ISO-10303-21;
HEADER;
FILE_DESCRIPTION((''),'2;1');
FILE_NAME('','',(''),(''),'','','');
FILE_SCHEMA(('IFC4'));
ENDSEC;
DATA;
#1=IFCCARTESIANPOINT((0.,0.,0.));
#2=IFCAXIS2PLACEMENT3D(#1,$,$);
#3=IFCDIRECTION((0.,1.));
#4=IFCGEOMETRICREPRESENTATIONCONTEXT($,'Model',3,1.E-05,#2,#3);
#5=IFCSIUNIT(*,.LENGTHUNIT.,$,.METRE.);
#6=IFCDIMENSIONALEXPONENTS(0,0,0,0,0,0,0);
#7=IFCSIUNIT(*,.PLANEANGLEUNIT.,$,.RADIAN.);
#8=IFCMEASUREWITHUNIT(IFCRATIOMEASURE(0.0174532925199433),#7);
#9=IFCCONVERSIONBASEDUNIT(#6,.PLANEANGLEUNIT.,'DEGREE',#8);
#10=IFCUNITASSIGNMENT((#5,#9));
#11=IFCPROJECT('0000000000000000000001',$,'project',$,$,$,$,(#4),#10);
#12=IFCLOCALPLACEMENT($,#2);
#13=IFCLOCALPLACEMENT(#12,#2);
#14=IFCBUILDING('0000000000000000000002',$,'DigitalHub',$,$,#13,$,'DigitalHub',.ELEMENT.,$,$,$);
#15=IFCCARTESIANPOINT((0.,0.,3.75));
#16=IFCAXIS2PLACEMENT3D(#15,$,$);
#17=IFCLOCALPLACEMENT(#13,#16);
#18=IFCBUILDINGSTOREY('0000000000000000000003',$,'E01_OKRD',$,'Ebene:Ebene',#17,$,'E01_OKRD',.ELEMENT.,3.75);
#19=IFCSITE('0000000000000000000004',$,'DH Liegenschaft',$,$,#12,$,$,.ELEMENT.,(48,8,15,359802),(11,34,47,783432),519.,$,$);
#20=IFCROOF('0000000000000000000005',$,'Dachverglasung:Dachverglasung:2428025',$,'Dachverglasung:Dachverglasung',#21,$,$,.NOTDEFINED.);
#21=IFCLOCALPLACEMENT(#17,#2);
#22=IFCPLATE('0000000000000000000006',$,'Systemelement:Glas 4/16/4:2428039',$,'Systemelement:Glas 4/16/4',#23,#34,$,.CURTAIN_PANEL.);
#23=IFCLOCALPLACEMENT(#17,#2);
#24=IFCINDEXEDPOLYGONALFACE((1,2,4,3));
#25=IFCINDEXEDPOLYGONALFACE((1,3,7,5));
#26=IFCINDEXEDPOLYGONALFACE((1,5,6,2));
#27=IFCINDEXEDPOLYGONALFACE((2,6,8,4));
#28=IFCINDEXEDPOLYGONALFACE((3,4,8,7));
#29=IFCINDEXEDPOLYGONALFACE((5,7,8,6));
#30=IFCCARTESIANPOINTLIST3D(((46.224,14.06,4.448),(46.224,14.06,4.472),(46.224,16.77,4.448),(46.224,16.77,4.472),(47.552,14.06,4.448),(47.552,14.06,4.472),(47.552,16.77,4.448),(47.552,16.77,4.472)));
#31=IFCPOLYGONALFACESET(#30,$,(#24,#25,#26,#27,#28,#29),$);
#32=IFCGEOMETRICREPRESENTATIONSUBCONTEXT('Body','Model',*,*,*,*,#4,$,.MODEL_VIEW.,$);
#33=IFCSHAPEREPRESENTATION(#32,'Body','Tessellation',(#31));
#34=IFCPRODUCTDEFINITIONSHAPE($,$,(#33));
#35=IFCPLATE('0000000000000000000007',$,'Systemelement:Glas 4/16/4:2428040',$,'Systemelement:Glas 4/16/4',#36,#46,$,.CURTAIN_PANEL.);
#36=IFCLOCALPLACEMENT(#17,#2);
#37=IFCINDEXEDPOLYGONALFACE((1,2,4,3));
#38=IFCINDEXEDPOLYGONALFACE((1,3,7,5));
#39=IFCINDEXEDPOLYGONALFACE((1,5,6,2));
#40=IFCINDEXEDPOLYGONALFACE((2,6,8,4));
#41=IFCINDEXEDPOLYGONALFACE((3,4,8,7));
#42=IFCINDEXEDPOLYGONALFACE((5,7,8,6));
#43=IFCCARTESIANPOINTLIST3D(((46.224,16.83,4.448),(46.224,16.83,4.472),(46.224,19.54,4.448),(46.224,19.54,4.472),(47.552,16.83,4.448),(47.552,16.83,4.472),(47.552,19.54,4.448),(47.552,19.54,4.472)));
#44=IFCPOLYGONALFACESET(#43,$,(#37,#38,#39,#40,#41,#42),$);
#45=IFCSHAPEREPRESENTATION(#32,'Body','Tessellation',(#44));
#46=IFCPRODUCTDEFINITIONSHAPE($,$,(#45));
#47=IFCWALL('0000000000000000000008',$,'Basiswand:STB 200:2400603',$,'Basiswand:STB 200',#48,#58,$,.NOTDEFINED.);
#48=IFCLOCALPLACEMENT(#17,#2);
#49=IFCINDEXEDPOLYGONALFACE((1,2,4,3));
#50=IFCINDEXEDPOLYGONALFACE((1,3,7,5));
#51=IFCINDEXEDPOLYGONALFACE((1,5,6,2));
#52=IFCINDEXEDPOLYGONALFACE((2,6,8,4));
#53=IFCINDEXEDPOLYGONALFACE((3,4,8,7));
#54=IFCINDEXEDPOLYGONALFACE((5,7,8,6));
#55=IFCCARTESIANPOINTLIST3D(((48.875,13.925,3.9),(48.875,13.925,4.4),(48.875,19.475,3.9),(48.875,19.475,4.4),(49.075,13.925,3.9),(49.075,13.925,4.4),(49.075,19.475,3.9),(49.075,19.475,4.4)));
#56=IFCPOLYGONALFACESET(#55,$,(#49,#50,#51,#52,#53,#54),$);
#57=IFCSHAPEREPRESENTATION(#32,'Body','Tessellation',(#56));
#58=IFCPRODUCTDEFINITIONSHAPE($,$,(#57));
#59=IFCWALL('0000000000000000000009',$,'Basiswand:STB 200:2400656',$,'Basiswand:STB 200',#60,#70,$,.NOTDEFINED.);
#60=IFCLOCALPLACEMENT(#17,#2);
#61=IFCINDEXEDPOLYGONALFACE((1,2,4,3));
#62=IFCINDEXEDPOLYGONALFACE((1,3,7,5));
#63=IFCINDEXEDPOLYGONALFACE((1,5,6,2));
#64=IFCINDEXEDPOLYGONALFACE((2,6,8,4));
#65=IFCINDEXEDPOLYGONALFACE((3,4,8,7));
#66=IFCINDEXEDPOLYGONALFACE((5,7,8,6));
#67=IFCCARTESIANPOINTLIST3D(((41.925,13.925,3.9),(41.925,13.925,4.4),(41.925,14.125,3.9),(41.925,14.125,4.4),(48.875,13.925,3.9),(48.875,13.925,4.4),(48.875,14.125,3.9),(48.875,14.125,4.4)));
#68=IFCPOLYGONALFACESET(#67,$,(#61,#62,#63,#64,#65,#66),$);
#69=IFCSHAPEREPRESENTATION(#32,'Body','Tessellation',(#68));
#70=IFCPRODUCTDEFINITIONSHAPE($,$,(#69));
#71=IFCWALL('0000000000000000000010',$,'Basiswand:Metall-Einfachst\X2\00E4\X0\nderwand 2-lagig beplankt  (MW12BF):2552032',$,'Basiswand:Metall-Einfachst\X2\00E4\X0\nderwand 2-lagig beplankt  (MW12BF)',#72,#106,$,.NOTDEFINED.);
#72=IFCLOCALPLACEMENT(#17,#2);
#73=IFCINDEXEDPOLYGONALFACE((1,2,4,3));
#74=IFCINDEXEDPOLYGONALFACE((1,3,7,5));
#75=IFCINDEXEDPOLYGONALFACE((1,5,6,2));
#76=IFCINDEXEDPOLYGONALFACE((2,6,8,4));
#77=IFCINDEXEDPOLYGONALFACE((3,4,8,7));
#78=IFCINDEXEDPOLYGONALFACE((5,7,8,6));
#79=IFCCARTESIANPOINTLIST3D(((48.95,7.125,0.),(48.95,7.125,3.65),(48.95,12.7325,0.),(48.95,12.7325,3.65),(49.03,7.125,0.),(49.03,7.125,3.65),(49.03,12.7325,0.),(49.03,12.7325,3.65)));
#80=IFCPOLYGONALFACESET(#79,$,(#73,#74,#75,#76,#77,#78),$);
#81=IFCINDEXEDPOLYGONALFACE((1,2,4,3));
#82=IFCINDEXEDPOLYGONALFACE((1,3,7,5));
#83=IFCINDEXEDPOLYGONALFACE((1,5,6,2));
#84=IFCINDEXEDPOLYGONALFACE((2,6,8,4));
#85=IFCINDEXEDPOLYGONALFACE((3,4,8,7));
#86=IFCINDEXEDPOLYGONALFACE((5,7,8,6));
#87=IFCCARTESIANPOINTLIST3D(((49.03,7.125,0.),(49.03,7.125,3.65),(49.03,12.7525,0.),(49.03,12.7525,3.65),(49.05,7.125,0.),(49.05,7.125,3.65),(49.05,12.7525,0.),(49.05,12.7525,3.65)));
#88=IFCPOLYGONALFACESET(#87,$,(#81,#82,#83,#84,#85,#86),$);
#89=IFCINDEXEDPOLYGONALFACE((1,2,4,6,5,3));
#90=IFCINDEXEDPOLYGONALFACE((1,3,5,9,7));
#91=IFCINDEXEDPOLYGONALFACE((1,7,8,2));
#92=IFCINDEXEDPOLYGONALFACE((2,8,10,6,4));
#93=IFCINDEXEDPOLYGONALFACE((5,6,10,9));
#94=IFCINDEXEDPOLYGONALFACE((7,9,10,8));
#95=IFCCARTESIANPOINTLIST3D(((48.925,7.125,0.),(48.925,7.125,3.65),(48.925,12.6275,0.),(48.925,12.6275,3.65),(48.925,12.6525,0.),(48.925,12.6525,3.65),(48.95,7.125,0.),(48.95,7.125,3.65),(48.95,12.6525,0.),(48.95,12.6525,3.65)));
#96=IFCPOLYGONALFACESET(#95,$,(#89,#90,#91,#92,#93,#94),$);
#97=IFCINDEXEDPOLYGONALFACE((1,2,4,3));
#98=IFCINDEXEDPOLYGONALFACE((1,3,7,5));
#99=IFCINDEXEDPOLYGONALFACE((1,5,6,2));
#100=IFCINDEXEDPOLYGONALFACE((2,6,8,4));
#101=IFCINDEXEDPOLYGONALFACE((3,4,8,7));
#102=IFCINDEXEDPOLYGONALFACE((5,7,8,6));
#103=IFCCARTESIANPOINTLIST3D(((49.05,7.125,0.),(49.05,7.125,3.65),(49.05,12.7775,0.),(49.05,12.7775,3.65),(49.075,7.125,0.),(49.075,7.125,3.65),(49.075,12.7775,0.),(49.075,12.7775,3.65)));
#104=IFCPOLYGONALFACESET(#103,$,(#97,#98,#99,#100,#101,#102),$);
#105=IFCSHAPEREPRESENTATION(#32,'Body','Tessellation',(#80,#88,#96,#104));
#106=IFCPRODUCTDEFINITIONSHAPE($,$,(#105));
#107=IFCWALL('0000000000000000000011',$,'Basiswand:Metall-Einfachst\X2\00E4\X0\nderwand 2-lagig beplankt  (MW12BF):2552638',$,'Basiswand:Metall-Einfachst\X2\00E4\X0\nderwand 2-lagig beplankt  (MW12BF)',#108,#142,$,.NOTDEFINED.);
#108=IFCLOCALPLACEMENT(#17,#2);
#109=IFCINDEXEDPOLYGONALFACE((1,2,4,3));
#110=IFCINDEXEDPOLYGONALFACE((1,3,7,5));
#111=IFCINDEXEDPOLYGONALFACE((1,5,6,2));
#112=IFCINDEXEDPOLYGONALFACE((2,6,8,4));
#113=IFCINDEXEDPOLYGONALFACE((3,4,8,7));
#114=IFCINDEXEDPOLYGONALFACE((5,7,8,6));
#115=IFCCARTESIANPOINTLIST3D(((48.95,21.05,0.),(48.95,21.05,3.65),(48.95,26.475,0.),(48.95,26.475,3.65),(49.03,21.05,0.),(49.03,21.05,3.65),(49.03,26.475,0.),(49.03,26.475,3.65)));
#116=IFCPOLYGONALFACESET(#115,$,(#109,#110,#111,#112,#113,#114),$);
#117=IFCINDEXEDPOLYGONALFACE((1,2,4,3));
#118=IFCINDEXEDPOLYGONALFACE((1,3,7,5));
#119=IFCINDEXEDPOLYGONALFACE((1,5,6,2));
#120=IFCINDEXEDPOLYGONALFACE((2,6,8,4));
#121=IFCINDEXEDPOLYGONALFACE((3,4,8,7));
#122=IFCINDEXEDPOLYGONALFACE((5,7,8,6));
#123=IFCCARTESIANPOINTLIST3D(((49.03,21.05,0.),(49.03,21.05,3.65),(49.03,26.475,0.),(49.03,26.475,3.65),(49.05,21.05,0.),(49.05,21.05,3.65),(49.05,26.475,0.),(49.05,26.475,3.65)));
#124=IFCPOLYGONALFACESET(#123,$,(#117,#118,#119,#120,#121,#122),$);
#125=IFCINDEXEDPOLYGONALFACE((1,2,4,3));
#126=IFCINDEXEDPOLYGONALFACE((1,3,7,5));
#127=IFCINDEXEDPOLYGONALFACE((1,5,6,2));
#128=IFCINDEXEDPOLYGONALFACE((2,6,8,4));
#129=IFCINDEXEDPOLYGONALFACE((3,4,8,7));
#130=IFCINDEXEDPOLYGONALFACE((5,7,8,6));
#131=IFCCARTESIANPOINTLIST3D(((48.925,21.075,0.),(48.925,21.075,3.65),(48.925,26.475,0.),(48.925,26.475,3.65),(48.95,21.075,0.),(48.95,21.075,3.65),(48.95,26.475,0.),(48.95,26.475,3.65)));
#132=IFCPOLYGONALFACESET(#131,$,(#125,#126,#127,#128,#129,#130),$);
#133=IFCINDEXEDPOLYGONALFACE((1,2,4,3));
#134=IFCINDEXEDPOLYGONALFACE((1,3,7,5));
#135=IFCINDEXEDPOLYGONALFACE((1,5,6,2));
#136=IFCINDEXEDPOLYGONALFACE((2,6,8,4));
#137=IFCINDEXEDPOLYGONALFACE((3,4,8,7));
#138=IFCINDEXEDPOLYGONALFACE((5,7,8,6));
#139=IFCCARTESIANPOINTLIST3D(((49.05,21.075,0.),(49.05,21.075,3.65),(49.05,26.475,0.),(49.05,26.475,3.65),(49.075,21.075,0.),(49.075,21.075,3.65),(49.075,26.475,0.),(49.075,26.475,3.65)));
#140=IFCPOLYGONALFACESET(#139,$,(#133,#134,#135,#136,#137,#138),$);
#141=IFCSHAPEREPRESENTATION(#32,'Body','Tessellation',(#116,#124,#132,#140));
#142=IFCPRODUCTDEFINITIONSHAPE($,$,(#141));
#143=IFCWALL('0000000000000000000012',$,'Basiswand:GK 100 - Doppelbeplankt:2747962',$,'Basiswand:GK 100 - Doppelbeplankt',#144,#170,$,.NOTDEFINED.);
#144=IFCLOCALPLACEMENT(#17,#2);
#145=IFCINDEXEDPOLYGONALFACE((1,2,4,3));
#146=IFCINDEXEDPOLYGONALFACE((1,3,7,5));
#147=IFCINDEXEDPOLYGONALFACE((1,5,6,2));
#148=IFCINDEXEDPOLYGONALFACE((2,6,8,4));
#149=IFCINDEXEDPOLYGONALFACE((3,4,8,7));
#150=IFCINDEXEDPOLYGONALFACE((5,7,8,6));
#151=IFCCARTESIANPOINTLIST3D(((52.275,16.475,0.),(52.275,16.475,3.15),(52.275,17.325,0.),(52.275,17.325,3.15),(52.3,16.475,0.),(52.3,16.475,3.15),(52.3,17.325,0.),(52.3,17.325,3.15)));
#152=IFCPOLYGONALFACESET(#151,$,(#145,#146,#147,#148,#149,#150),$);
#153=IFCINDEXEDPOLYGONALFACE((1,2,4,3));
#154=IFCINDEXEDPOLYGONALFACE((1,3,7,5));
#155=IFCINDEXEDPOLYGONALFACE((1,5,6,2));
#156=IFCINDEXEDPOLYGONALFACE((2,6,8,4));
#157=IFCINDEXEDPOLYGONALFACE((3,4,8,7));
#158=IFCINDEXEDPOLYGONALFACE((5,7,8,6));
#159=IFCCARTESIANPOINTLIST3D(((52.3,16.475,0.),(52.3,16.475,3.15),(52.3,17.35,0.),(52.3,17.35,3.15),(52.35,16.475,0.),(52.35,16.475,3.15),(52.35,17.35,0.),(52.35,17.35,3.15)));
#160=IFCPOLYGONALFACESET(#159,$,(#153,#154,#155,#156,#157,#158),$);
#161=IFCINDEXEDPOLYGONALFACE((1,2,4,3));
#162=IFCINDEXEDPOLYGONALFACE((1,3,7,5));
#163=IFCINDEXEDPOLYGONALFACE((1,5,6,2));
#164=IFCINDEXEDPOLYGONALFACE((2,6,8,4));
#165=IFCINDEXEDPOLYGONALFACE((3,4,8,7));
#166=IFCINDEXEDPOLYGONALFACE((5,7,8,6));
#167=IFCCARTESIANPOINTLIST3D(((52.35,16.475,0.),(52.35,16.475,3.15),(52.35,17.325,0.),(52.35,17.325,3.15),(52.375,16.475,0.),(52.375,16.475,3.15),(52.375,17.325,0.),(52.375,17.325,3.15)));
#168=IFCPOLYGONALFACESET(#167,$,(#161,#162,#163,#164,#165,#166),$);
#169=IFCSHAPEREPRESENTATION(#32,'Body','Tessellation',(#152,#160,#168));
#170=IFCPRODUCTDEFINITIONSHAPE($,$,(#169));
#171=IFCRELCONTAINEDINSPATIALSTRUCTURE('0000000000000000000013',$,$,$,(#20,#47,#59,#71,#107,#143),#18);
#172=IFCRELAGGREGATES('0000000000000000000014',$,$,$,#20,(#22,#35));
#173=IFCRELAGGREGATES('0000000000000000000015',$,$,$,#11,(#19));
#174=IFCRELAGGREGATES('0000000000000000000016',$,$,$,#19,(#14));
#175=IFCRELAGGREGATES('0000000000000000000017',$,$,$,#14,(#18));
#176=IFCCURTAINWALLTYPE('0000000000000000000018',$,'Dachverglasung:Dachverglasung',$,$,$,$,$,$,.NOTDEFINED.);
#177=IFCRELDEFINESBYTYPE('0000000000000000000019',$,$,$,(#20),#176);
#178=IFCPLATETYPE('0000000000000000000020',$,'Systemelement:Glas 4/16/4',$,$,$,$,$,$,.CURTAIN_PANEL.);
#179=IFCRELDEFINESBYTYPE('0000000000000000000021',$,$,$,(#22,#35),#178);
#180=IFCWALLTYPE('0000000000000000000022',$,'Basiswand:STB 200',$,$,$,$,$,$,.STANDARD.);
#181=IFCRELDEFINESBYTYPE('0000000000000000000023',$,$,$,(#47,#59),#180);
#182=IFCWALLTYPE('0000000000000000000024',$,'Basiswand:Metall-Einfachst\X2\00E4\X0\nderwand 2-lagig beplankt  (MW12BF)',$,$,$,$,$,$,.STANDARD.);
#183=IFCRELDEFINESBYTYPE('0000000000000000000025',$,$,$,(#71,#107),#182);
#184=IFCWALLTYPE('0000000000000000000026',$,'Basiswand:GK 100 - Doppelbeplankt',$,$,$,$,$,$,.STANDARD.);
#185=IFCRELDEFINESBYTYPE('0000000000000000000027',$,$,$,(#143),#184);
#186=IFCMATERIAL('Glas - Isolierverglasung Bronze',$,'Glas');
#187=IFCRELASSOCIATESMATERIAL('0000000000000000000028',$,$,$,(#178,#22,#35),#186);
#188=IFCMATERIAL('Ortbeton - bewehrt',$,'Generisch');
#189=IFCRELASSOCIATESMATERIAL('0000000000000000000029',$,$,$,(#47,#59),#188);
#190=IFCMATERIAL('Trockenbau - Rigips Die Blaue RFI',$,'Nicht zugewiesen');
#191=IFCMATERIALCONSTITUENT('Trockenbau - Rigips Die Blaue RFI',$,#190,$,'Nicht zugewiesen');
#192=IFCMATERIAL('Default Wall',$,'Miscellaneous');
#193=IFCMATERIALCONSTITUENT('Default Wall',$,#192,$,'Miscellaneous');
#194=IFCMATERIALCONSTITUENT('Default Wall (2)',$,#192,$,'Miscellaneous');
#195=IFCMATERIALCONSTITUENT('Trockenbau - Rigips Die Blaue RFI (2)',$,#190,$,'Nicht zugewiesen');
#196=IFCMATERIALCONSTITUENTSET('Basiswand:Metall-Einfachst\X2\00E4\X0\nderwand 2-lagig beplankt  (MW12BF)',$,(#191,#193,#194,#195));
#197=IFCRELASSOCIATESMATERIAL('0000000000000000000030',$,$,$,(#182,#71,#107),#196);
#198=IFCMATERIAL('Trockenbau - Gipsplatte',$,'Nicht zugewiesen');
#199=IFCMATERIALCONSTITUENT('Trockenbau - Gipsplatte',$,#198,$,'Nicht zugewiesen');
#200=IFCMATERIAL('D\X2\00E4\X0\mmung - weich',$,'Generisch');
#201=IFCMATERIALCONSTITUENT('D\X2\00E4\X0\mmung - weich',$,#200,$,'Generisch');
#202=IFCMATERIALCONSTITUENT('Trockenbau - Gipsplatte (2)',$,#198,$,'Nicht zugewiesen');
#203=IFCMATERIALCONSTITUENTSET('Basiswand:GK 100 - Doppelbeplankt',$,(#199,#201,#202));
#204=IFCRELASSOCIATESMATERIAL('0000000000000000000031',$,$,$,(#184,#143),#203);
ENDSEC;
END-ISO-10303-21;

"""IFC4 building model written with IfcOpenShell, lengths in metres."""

from ifc_helpers import new_model, entity, si_unit, converted_unit, direction, frame, origin, place, context, subcontext, project, spatial, indexed_curve, outline, extrude, source, transform, mapped, material, constituent, constituent_set, type_object, type_shapes, element, aggregate, save


model = new_model("IFC4")

# Units and contexts
model_context = context("Model", 3, precision=1e-05, world=origin(), true_north=direction((0.0, 1.0)))
body_context = subcontext(model_context, "Body", "Model", "MODEL_VIEW")
ifc_project = project(units=[si_unit("LENGTHUNIT", "METRE"), converted_unit("PLANEANGLEUNIT", "DEGREE", entity("IfcRatioMeasure", 0.0174532925199433), si_unit("PLANEANGLEUNIT", "RADIAN"), dimensions=[0, 0, 0, 0, 0, 0, 0])], contexts=[model_context])

# Site, building, storey
site_placement = place(None, frame((0.0, 0.0, 0.0)))
site = spatial("IfcSite", under=ifc_project, at=site_placement, Name="DH Liegenschaft", CompositionType="ELEMENT", RefLatitude=(48, 8, 15, 359802), RefLongitude=(11, 34, 47, 783432), RefElevation=519.0)
building_placement = place(site_placement, origin())
building = spatial("IfcBuilding", under=site, at=building_placement, Name="DigitalHub", LongName="DigitalHub", CompositionType="ELEMENT")
storey_placement = place(building_placement, frame((0.0, 0.0, 3.75)))
storey = spatial("IfcBuildingStorey", under=building, at=storey_placement, Name="E01_OKRD", ObjectType="Ebene:Ebene", LongName="E01_OKRD", CompositionType="ELEMENT", Elevation=3.75)

# Roof, plates
curtain_wall_type = type_object("IfcCurtainWallType", Name="Dachverglasung:Dachverglasung", PredefinedType="NOTDEFINED")
roof_placement = place(storey_placement, frame((0.0, 0.0, -3.75)))
roof = element("IfcRoof", 1, at=roof_placement, inside=storey, type_object=curtain_wall_type, Name="Dachverglasung:Dachverglasung:2428025", ObjectType="Dachverglasung:Dachverglasung", PredefinedType="NOTDEFINED")
ifc_material_1 = material(Name="Glas - Isolierverglasung Bronze", Category="Glas")
plate_type = type_object("IfcPlateType", Name="Systemelement:Glas 4/16/4", PredefinedType="CURTAIN_PANEL", material=ifc_material_1)
shared_shape_1 = source(origin(), body_context, "Body", "SweptSolid", [
    extrude(outline(indexed_curve([(-0.012, -1.355), (0.012, -1.355), (0.012, 1.355), (-0.012, 1.355), (-0.012, -1.355)], self_intersect=False)), frame((0.0, 0.0, 0.0), z_axis=(0.0, 0.0, 1.0), x_axis=(0.0, 1.0, 0.0)), (0.0, 0.0, 1.0), 1.328),
])
type_shapes(plate_type, [shared_shape_1])
plate_1_placement = place(roof_placement, frame((47.552, 15.415, 8.21), z_axis=(-1.0, 0.0, 0.0), x_axis=(0.0, 1.0, 0.0)))
plate_1 = element("IfcPlate", 2, at=plate_1_placement, type_object=plate_type, material=ifc_material_1, Name="Systemelement:Glas 4/16/4:2428039", ObjectType="Systemelement:Glas 4/16/4", PredefinedType="CURTAIN_PANEL", context=body_context, shape_type="MappedRepresentation", body=[
    mapped(shared_shape_1, transform((0.0, 0.0, 0.0), scale=1.0)),
])
plate_2_placement = place(roof_placement, frame((47.552, 18.185, 8.21), z_axis=(-1.0, 0.0, 0.0), x_axis=(0.0, 1.0, 0.0)))
plate_2 = element("IfcPlate", 3, at=plate_2_placement, type_object=plate_type, material=ifc_material_1, Name="Systemelement:Glas 4/16/4:2428040", ObjectType="Systemelement:Glas 4/16/4", PredefinedType="CURTAIN_PANEL", context=body_context, shape_type="MappedRepresentation", body=[
    mapped(shared_shape_1, transform((0.0, 0.0, 0.0), scale=1.0)),
])
aggregate(roof, [plate_1, plate_2])

# Walls
ifc_material_2 = material(Name="Ortbeton - bewehrt", Category="Generisch")
wall_type_1 = type_object("IfcWallType", Name="Basiswand:STB 200", PredefinedType="STANDARD")
wall_1_placement = place(storey_placement, frame((48.975, 19.475, 3.9), z_axis=(0.0, 0.0, 1.0), x_axis=(0.0, -1.0, 0.0)))
element("IfcWall", 4, at=wall_1_placement, inside=storey, type_object=wall_type_1, material=ifc_material_2, Name="Basiswand:STB 200:2400603", ObjectType="Basiswand:STB 200", PredefinedType="NOTDEFINED", context=body_context, shape_type="SweptSolid", body=[
    extrude(outline(indexed_curve([(5.55, 0.1), (0.0, 0.1), (0.0, -0.1), (5.55, -0.1), (5.55, 0.1)], self_intersect=False)), origin(), (0.0, 0.0, 1.0), 0.5),
])
wall_2_placement = place(storey_placement, frame((48.875, 14.025, 3.9), z_axis=(0.0, 0.0, 1.0), x_axis=(-1.0, 0.0, 0.0)))
element("IfcWall", 5, at=wall_2_placement, inside=storey, type_object=wall_type_1, material=ifc_material_2, Name="Basiswand:STB 200:2400656", ObjectType="Basiswand:STB 200", PredefinedType="NOTDEFINED", context=body_context, shape_type="SweptSolid", body=[
    extrude(outline(indexed_curve([(6.95, 0.1), (0.0, 0.1), (0.0, -0.1), (6.95, -0.1), (6.95, 0.1)], self_intersect=False)), origin(), (0.0, 0.0, 1.0), 0.5),
])

# Shared definitions
ifc_material_3 = material(Name="Trockenbau - Rigips Die Blaue RFI", Category="Nicht zugewiesen")
ifc_constituent_1 = constituent(ifc_material_3, Name="Trockenbau - Rigips Die Blaue RFI", Category="Nicht zugewiesen")
ifc_material_4 = material(Name="Default Wall", Category="Miscellaneous")
ifc_constituent_2 = constituent(ifc_material_4, Name="Default Wall", Category="Miscellaneous")
ifc_constituent_3 = constituent(ifc_material_4, Name="Default Wall (2)", Category="Miscellaneous")
ifc_constituent_4 = constituent(ifc_material_3, Name="Trockenbau - Rigips Die Blaue RFI (2)", Category="Nicht zugewiesen")
ifc_constituent_set_1 = constituent_set(constituents=[ifc_constituent_1, ifc_constituent_2, ifc_constituent_3, ifc_constituent_4], Name="Basiswand:Metall-Einfachständerwand 2-lagig beplankt  (MW12BF)")
wall_type_2 = type_object("IfcWallType", Name="Basiswand:Metall-Einfachständerwand 2-lagig beplankt  (MW12BF)", PredefinedType="STANDARD", material=ifc_constituent_set_1)

# Walls
wall_3_placement = place(storey_placement, frame((49.0, 7.125, 0.0), z_axis=(0.0, 0.0, 1.0), x_axis=(0.0, 1.0, 0.0)))
element("IfcWall", 6, at=wall_3_placement, inside=storey, type_object=wall_type_2, material=ifc_constituent_set_1, Name="Basiswand:Metall-Einfachständerwand 2-lagig beplankt  (MW12BF):2552032", ObjectType="Basiswand:Metall-Einfachständerwand 2-lagig beplankt  (MW12BF)", PredefinedType="NOTDEFINED", context=body_context, shape_type="SweptSolid", body=[
    extrude(outline(indexed_curve([(-2.8038, -0.04), (2.8038, -0.04), (2.8038, 0.04), (-2.8038, 0.04), (-2.8038, -0.04)], self_intersect=False)), frame((2.8038, 0.01, 0.0)), (0.0, 0.0, 1.0), 3.65),
    extrude(outline(indexed_curve([(-2.8138, -0.01), (2.8138, -0.01), (2.8138, 0.01), (-2.8138, 0.01), (-2.8138, -0.01)], self_intersect=False)), frame((2.8138, -0.04, 0.0)), (0.0, 0.0, 1.0), 3.65),
    extrude(outline(indexed_curve([(-2.191, -0.01), (3.3115, -0.01), (3.3115, 0.015), (-2.216, 0.015), (-2.216, -0.01), (-2.191, -0.01)], self_intersect=False)), frame((3.3115, 0.065, 0.0), z_axis=(0.0, 0.0, 1.0), x_axis=(-1.0, 0.0, 0.0)), (0.0, 0.0, 1.0), 3.65),
    extrude(outline(indexed_curve([(-0.0125, -2.8263), (0.0125, -2.8263), (0.0125, 2.8263), (-0.0125, 2.8263), (-0.0125, -2.8263)], self_intersect=False)), frame((2.8263, -0.0625, 0.0), z_axis=(0.0, 0.0, 1.0), x_axis=(0.0, 1.0, 0.0)), (0.0, 0.0, 1.0), 3.65),
])
wall_4_placement = place(storey_placement, frame((49.0, 21.075, 0.0), z_axis=(0.0, 0.0, 1.0), x_axis=(0.0, 1.0, 0.0)))
element("IfcWall", 7, at=wall_4_placement, inside=storey, type_object=wall_type_2, material=ifc_constituent_set_1, Name="Basiswand:Metall-Einfachständerwand 2-lagig beplankt  (MW12BF):2552638", ObjectType="Basiswand:Metall-Einfachständerwand 2-lagig beplankt  (MW12BF)", PredefinedType="NOTDEFINED", context=body_context, shape_type="SweptSolid", body=[
    extrude(outline(indexed_curve([(-2.7125, -0.04), (2.7125, -0.04), (2.7125, 0.04), (-2.7125, 0.04), (-2.7125, -0.04)], self_intersect=False)), frame((2.6875, 0.01, 0.0)), (0.0, 0.0, 1.0), 3.65),
    extrude(outline(indexed_curve([(-2.7125, -0.01), (2.7125, -0.01), (2.7125, 0.01), (-2.7125, 0.01), (-2.7125, -0.01)], self_intersect=False)), frame((2.6875, -0.04, 0.0)), (0.0, 0.0, 1.0), 3.65),
    extrude(outline(indexed_curve([(-0.0125, -2.7), (0.0125, -2.7), (0.0125, 2.7), (-0.0125, 2.7), (-0.0125, -2.7)], self_intersect=False)), frame((2.7, 0.0625, 0.0), z_axis=(0.0, 0.0, 1.0), x_axis=(0.0, -1.0, 0.0)), (0.0, 0.0, 1.0), 3.65),
    extrude(outline(indexed_curve([(-0.0125, -2.7), (0.0125, -2.7), (0.0125, 2.7), (-0.0125, 2.7), (-0.0125, -2.7)], self_intersect=False)), frame((2.7, -0.0625, 0.0), z_axis=(0.0, 0.0, 1.0), x_axis=(0.0, 1.0, 0.0)), (0.0, 0.0, 1.0), 3.65),
])

# Wall
ifc_material_5 = material(Name="Trockenbau - Gipsplatte", Category="Nicht zugewiesen")
ifc_constituent_5 = constituent(ifc_material_5, Name="Trockenbau - Gipsplatte", Category="Nicht zugewiesen")
ifc_material_6 = material(Name="Dämmung - weich", Category="Generisch")
ifc_constituent_6 = constituent(ifc_material_6, Name="Dämmung - weich", Category="Generisch")
ifc_constituent_7 = constituent(ifc_material_5, Name="Trockenbau - Gipsplatte (2)", Category="Nicht zugewiesen")
ifc_constituent_set_2 = constituent_set(constituents=[ifc_constituent_5, ifc_constituent_6, ifc_constituent_7], Name="Basiswand:GK 100 - Doppelbeplankt")
wall_type_3 = type_object("IfcWallType", Name="Basiswand:GK 100 - Doppelbeplankt", PredefinedType="STANDARD", material=ifc_constituent_set_2)
wall_5_placement = place(storey_placement, frame((52.325, 17.325, 0.0), z_axis=(0.0, 0.0, 1.0), x_axis=(0.0, -1.0, 0.0)))
element("IfcWall", 8, at=wall_5_placement, inside=storey, type_object=wall_type_3, material=ifc_constituent_set_2, Name="Basiswand:GK 100 - Doppelbeplankt:2747962", ObjectType="Basiswand:GK 100 - Doppelbeplankt", PredefinedType="NOTDEFINED", context=body_context, shape_type="SweptSolid", body=[
    extrude(outline(indexed_curve([(-0.0125, -0.425), (0.0125, -0.425), (0.0125, 0.425), (-0.0125, 0.425), (-0.0125, -0.425)], self_intersect=False)), frame((0.425, -0.0375, 0.0), z_axis=(0.0, 0.0, 1.0), x_axis=(0.0, 1.0, 0.0)), (0.0, 0.0, 1.0), 3.15),
    extrude(outline(indexed_curve([(-0.4375, -0.025), (0.4375, -0.025), (0.4375, 0.025), (-0.4375, 0.025), (-0.4375, -0.025)], self_intersect=False)), frame((0.4125, 0.0, 0.0)), (0.0, 0.0, 1.0), 3.15),
    extrude(outline(indexed_curve([(-0.0125, -0.425), (0.0125, -0.425), (0.0125, 0.425), (-0.0125, 0.425), (-0.0125, -0.425)], self_intersect=False)), frame((0.425, 0.0375, 0.0), z_axis=(0.0, 0.0, 1.0), x_axis=(0.0, -1.0, 0.0)), (0.0, 0.0, 1.0), 3.15),
])

save(model, "model.ifc")
